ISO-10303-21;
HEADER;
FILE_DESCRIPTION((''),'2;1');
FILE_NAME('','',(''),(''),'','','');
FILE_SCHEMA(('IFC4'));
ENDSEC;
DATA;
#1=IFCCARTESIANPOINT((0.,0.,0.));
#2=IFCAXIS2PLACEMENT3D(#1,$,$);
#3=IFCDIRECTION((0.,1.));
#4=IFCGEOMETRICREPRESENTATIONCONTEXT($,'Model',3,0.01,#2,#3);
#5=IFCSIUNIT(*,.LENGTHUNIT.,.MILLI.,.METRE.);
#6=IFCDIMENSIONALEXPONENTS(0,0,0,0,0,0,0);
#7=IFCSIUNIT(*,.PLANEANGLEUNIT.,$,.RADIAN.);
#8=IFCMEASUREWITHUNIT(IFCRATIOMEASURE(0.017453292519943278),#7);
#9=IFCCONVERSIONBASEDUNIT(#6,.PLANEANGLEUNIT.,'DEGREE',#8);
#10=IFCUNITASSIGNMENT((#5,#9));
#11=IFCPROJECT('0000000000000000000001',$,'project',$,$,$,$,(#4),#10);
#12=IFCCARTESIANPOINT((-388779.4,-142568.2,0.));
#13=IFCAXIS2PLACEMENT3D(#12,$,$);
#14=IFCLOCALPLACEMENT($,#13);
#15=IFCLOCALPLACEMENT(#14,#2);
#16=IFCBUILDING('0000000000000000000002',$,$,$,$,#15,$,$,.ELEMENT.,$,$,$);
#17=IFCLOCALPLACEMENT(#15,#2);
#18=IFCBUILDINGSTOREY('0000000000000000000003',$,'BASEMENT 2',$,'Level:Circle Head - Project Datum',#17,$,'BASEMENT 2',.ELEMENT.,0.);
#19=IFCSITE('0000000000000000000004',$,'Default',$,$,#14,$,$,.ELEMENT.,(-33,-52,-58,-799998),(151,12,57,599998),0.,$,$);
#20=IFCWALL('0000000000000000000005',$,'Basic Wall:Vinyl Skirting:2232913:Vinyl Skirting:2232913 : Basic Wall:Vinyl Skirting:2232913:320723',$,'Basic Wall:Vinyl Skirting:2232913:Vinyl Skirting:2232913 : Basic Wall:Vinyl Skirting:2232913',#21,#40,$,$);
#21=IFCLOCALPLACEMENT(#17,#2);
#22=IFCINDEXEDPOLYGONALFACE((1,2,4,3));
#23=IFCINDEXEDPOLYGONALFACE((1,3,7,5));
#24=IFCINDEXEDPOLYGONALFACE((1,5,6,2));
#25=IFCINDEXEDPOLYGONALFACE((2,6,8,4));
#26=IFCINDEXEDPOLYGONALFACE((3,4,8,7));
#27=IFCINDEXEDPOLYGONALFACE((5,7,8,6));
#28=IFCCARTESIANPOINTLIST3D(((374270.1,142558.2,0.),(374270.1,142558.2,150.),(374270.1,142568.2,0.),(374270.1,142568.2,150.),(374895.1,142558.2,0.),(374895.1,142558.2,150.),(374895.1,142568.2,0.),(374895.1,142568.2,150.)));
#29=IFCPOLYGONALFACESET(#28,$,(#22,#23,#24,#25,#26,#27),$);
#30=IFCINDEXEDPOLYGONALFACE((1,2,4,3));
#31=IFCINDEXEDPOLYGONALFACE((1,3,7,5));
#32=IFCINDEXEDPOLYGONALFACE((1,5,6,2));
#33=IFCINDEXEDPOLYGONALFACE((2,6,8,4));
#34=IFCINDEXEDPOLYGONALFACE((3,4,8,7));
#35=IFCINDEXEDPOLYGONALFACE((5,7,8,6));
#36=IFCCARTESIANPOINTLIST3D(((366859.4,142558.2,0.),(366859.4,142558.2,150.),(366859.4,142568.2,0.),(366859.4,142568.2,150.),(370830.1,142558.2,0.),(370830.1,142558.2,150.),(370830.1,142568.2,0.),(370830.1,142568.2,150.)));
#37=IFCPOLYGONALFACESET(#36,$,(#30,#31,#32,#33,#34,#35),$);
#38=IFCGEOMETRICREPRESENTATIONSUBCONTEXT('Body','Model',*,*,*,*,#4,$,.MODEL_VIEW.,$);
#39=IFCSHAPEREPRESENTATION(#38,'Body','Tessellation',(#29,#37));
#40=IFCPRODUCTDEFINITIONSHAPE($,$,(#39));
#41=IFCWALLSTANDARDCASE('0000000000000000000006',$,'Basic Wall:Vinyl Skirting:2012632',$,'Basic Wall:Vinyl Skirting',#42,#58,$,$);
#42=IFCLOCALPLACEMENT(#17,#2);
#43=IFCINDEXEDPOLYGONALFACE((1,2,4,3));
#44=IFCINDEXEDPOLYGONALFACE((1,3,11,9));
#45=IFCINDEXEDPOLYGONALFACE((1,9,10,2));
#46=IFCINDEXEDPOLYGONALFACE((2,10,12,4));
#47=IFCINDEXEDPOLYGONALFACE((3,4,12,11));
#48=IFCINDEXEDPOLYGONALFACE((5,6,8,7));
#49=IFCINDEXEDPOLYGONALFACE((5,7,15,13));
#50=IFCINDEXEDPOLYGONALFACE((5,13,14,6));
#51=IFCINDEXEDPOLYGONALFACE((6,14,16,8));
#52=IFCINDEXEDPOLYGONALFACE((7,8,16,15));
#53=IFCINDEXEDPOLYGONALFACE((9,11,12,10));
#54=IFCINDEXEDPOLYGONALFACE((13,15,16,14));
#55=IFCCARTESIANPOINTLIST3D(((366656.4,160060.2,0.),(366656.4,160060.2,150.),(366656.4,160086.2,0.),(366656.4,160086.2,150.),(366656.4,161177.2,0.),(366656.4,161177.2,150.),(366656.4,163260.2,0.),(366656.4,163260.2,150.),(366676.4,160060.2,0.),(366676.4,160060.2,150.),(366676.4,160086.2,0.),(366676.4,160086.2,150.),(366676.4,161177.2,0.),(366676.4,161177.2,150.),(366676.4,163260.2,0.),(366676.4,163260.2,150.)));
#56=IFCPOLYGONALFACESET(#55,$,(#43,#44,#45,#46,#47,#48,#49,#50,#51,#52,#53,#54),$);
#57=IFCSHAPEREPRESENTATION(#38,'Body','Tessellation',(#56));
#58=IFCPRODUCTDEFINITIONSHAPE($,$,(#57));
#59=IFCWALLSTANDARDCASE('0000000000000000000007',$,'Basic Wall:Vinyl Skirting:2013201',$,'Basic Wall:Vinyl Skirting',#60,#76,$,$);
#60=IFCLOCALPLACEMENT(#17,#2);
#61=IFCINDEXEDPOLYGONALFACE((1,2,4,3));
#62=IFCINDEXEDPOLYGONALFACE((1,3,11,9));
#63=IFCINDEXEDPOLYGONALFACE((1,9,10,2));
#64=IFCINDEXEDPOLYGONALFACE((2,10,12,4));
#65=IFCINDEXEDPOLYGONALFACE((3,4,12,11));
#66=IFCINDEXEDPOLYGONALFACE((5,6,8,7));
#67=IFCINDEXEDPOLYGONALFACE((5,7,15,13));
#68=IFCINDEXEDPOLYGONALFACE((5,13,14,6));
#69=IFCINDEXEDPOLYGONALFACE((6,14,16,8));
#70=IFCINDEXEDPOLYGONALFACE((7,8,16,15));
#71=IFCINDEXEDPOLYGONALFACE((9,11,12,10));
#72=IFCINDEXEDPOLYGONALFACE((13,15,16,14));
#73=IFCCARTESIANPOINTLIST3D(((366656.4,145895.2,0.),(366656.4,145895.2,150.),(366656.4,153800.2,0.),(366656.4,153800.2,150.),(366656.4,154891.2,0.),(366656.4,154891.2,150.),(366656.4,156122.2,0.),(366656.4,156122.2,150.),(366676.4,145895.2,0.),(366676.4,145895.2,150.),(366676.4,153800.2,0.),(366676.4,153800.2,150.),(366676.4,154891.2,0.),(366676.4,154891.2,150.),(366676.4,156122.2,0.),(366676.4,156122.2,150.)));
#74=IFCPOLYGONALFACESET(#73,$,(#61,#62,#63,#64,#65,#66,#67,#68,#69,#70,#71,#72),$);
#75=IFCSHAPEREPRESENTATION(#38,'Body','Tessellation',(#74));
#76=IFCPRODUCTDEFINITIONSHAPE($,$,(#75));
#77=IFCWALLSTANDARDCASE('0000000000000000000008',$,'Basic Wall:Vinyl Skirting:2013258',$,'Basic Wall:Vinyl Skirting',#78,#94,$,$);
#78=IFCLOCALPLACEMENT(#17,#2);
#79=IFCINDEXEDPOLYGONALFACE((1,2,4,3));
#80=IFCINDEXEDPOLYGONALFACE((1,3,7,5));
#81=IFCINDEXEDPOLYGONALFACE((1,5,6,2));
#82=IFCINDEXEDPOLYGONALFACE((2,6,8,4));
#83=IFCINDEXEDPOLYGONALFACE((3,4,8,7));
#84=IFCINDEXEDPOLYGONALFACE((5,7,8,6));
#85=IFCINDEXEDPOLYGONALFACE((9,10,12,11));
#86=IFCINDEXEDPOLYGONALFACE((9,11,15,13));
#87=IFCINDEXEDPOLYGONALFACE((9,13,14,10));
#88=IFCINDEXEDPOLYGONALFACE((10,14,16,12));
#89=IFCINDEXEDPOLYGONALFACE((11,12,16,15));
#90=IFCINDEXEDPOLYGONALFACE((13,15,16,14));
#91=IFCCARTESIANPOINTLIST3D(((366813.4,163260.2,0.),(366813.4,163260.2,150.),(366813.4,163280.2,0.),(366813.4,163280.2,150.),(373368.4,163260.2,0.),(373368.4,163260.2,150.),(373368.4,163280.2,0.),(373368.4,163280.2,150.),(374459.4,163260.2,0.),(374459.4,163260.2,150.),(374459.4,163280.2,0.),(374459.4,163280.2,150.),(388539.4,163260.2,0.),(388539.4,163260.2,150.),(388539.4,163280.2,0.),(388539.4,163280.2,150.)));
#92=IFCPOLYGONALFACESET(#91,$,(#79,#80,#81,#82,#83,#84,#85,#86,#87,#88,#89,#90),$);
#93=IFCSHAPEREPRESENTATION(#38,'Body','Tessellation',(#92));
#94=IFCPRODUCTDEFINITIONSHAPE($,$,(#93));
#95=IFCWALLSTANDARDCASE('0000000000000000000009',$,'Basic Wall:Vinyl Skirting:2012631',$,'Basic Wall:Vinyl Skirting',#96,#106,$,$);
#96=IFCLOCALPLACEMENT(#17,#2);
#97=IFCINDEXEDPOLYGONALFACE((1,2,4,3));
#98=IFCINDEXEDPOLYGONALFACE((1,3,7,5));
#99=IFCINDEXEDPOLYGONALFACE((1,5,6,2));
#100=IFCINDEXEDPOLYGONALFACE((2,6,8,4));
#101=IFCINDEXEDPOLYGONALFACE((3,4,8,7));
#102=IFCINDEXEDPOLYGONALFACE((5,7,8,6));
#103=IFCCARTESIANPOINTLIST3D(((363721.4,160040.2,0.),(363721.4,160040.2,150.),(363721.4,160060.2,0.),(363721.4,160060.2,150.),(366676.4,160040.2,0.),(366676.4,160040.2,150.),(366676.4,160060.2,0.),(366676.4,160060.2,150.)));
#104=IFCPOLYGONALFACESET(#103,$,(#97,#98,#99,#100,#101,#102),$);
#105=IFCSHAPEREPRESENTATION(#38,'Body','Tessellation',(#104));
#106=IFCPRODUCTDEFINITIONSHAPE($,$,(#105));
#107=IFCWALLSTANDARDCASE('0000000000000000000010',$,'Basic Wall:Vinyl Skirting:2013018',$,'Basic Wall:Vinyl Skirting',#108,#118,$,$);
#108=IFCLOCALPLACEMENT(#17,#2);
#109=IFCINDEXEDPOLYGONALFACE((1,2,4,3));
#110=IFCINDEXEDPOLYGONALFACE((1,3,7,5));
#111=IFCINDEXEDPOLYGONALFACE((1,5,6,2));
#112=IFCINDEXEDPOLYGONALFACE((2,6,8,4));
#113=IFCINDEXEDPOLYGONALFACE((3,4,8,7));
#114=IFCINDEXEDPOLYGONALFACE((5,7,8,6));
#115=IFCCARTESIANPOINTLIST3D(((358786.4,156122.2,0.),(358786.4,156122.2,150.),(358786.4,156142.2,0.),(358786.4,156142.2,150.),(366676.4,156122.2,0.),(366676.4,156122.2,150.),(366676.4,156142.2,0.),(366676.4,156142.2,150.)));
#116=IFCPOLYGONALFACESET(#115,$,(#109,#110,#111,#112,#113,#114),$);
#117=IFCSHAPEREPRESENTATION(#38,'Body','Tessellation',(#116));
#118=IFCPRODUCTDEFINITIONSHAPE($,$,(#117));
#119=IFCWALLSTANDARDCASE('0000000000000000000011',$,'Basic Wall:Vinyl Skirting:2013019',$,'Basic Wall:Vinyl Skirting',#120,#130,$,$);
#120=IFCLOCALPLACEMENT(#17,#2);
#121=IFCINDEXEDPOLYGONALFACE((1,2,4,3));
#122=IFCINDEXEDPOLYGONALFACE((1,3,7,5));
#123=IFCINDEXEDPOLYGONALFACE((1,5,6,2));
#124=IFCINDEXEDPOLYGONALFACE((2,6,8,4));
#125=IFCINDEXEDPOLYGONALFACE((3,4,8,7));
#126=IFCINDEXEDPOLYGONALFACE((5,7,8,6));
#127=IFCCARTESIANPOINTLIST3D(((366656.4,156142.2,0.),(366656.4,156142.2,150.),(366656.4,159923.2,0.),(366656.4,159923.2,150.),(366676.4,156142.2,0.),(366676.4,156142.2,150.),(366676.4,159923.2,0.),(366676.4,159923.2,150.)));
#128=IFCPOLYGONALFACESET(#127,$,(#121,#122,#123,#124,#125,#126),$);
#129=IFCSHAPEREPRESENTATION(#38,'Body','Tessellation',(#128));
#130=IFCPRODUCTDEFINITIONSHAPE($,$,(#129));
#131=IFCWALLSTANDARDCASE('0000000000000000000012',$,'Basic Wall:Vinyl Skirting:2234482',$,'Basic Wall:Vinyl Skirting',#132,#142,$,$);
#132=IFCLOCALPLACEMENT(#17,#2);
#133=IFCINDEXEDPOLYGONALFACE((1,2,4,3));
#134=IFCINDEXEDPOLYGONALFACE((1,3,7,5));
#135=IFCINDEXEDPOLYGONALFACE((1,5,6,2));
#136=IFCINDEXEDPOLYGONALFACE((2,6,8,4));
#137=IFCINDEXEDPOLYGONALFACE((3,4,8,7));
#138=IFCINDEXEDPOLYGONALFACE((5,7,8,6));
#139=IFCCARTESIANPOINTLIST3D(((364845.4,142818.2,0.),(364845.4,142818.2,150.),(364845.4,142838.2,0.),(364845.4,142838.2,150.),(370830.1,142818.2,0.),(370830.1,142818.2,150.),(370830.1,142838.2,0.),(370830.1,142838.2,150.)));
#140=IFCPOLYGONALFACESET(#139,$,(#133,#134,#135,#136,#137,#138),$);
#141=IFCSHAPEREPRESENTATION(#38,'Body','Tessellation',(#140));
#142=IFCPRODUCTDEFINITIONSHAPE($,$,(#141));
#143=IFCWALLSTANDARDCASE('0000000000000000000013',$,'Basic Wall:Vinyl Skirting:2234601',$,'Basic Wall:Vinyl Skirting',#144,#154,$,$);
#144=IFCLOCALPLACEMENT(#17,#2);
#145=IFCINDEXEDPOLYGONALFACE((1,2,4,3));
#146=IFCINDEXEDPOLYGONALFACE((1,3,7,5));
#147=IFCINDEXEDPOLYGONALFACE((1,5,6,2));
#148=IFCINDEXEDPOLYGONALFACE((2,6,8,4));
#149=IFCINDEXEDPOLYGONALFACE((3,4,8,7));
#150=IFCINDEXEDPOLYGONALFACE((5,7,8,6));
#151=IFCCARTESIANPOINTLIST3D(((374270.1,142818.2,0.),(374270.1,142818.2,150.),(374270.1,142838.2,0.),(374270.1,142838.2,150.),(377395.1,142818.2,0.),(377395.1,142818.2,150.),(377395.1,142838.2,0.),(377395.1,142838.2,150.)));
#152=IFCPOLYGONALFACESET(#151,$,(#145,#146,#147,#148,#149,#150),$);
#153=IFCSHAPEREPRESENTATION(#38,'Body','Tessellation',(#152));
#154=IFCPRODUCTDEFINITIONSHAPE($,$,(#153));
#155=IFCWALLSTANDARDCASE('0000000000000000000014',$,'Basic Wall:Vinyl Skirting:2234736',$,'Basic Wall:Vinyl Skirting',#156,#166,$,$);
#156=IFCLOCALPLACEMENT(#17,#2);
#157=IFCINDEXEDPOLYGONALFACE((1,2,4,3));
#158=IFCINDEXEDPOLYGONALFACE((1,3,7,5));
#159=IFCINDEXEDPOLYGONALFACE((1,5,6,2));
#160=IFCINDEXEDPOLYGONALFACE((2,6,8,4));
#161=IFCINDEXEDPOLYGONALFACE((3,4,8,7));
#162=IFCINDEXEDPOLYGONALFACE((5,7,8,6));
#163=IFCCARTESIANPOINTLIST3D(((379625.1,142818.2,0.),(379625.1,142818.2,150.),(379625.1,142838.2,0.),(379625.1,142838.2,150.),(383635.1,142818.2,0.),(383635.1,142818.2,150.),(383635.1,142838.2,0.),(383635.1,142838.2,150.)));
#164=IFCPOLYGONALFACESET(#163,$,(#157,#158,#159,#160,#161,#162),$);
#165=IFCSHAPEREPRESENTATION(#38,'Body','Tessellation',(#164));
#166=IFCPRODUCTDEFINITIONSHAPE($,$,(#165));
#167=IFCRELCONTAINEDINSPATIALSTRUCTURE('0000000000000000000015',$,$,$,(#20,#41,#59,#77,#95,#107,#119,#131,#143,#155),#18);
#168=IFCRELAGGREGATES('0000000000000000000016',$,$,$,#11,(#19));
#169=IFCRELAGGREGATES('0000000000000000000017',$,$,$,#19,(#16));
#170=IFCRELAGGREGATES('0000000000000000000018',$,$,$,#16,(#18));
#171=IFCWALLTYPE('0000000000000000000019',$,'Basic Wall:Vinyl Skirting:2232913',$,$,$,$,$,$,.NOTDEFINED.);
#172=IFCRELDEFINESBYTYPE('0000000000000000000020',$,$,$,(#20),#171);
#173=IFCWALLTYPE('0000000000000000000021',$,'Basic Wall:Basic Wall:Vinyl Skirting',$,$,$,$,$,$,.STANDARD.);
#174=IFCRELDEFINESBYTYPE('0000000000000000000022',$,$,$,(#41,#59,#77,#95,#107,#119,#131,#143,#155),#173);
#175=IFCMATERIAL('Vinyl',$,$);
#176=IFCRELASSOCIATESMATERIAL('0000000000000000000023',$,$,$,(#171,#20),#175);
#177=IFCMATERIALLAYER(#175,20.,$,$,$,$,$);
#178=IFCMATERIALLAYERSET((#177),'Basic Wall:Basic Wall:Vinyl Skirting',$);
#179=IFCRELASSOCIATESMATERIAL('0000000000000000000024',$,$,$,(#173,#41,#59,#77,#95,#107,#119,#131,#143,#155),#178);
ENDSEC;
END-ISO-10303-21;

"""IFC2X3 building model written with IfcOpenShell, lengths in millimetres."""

from ifc_helpers import new_model, entity, si_unit, converted_unit, direction, frame, frame_2d, origin, origin_2d_with_axis, place, context, subcontext, project, spatial, rectangle, extrude, material, layer, layer_set, layer_usage, type_object, element, save


model = new_model("IFC2X3")

# Units and contexts
model_context = context("Model", 3, precision=0.01, world=origin(), true_north=direction((0.0, 1.0)))
body_context = subcontext(model_context, "Body", "Model", "MODEL_VIEW")
ifc_project = project(units=[si_unit("LENGTHUNIT", "METRE", prefix="MILLI"), converted_unit("PLANEANGLEUNIT", "DEGREE", entity("IfcRatioMeasure", 0.017453292519943278), si_unit("PLANEANGLEUNIT", "RADIAN"), dimensions=[0, 0, 0, 0, 0, 0, 0])], contexts=[model_context])

# Site, building, storey
site_placement = place(None, frame((-388779.4, -142568.2, 0.0)))
site = spatial("IfcSite", under=ifc_project, at=site_placement, Name="Default", CompositionType="ELEMENT", RefLatitude=(-33, -52, -58, -799998), RefLongitude=(151, 12, 57, 599998), RefElevation=0.0)
building_placement = place(site_placement, origin())
building = spatial("IfcBuilding", under=site, at=building_placement, CompositionType="ELEMENT")
storey_placement = place(building_placement, origin())
storey = spatial("IfcBuildingStorey", under=building, at=storey_placement, Name="BASEMENT 2", ObjectType="Level:Circle Head - Project Datum", LongName="BASEMENT 2", CompositionType="ELEMENT", Elevation=0.0)

# Wall
ifc_material_1 = material(Name="Vinyl")
wall_type_1 = type_object("IfcWallType", Name="Basic Wall:Vinyl Skirting:2232913", PredefinedType="NOTDEFINED", material=ifc_material_1)
wall_1_placement = place(storey_placement, frame((366859.4, 142558.2, 0.0)))
element("IfcWall", 1, at=wall_1_placement, inside=storey, type_object=wall_type_1, material=ifc_material_1, Name="Basic Wall:Vinyl Skirting:2232913:Vinyl Skirting:2232913 : Basic Wall:Vinyl Skirting:2232913:320723", ObjectType="Basic Wall:Vinyl Skirting:2232913:Vinyl Skirting:2232913 : Basic Wall:Vinyl Skirting:2232913", context=body_context, shape_type="SweptSolid", body=[
    extrude(rectangle(XDim=625.0, YDim=10.0, at=origin_2d_with_axis()), frame((7723.2, 5.0, 0.0), z_axis=(0.0, 0.0, 1.0), x_axis=(-1.0, 0.0, 0.0)), (0.0, 0.0, 1.0), 150.0),
    extrude(rectangle(XDim=3970.7, YDim=10.0, at=origin_2d_with_axis()), frame((1985.4, 5.0, 0.0), z_axis=(0.0, 0.0, 1.0), x_axis=(-1.0, 0.0, 0.0)), (0.0, 0.0, 1.0), 150.0),
])

# Shared definitions
ifc_layer_1 = layer(ifc_material_1, 20.0)
ifc_layer_set_1 = layer_set([ifc_layer_1], Name="Basic Wall:Basic Wall:Vinyl Skirting")
wall_type_2 = type_object("IfcWallType", Name="Basic Wall:Basic Wall:Vinyl Skirting", PredefinedType="STANDARD", material=ifc_layer_set_1)

# Wall, opening
ifc_layer_usage_1 = layer_usage(ifc_layer_set_1, "AXIS2", "NEGATIVE", 10.0)
wall_2_placement = place(storey_placement, frame((366666.4, 163260.2, 0.0), z_axis=(0.0, 0.0, 1.0), x_axis=(0.0, -1.0, 0.0)))
wall_2 = element("IfcWallStandardCase", 2, at=wall_2_placement, inside=storey, type_object=wall_type_2, material=ifc_layer_usage_1, Name="Basic Wall:Vinyl Skirting:2012632", ObjectType="Basic Wall:Vinyl Skirting", context=body_context, shape_type="SweptSolid", body=[
    extrude(rectangle(XDim=20.0, YDim=3200.0, at=frame_2d((1600.0, 0.0), x_axis=(0.0, -1.0))), origin(), (0.0, 0.0, 1.0), 150.0),
])
opening_1_placement = place(wall_2_placement, origin())
element("IfcOpeningElement", 3, at=opening_1_placement, cuts=wall_2, ObjectType="Opening", context=body_context, shape_type="SweptSolid", body=[
    extrude(rectangle(XDim=2185.0, YDim=1091.0, at=origin_2d_with_axis()), frame((2628.5, -10.0, 1092.5), z_axis=(0.0, 1.0, 0.0), x_axis=(0.0, 0.0, -1.0)), (0.0, 0.0, 1.0), 20.0),
])

# Walls, openings
ifc_layer_usage_2 = layer_usage(ifc_layer_set_1, "AXIS2", "NEGATIVE", 10.0)
wall_3_placement = place(storey_placement, frame((366666.4, 156122.2, 0.0), z_axis=(0.0, 0.0, 1.0), x_axis=(0.0, -1.0, 0.0)))
wall_3 = element("IfcWallStandardCase", 4, at=wall_3_placement, inside=storey, type_object=wall_type_2, material=ifc_layer_usage_2, Name="Basic Wall:Vinyl Skirting:2013201", ObjectType="Basic Wall:Vinyl Skirting", context=body_context, shape_type="SweptSolid", body=[
    extrude(rectangle(XDim=20.0, YDim=10227.0, at=frame_2d((5113.5, 0.0), x_axis=(0.0, -1.0))), origin(), (0.0, 0.0, 1.0), 150.0),
])
opening_2_placement = place(wall_3_placement, origin())
element("IfcOpeningElement", 5, at=opening_2_placement, cuts=wall_3, ObjectType="Opening", context=body_context, shape_type="SweptSolid", body=[
    extrude(rectangle(XDim=2185.0, YDim=1091.0, at=origin_2d_with_axis()), frame((1776.5, -10.0, 1092.5), z_axis=(0.0, 1.0, 0.0), x_axis=(0.0, 0.0, -1.0)), (0.0, 0.0, 1.0), 20.0),
])
ifc_layer_usage_3 = layer_usage(ifc_layer_set_1, "AXIS2", "NEGATIVE", 10.0)
wall_4_placement = place(storey_placement, frame((388539.4, 163270.2, 0.0), z_axis=(0.0, 0.0, 1.0), x_axis=(-1.0, 0.0, 0.0)))
wall_4 = element("IfcWallStandardCase", 6, at=wall_4_placement, inside=storey, type_object=wall_type_2, material=ifc_layer_usage_3, Name="Basic Wall:Vinyl Skirting:2013258", ObjectType="Basic Wall:Vinyl Skirting", context=body_context, shape_type="SweptSolid", body=[
    extrude(rectangle(XDim=20.0, YDim=21726.0, at=frame_2d((10863.0, 0.0), x_axis=(0.0, -1.0))), origin(), (0.0, 0.0, 1.0), 150.0),
])
opening_3_placement = place(wall_4_placement, origin())
element("IfcOpeningElement", 7, at=opening_3_placement, cuts=wall_4, ObjectType="Opening", context=body_context, shape_type="SweptSolid", body=[
    extrude(rectangle(XDim=2185.0, YDim=1091.0, at=origin_2d_with_axis()), frame((14625.5, -10.0, 1092.5), z_axis=(0.0, 1.0, 0.0), x_axis=(0.0, 0.0, -1.0)), (0.0, 0.0, 1.0), 20.0),
])

# Walls
ifc_layer_usage_4 = layer_usage(ifc_layer_set_1, "AXIS2", "NEGATIVE", 10.0)
wall_5_placement = place(storey_placement, frame((366676.4, 160050.2, 0.0), z_axis=(0.0, 0.0, 1.0), x_axis=(-1.0, 0.0, 0.0)))
element("IfcWallStandardCase", 8, at=wall_5_placement, inside=storey, type_object=wall_type_2, material=ifc_layer_usage_4, Name="Basic Wall:Vinyl Skirting:2012631", ObjectType="Basic Wall:Vinyl Skirting", context=body_context, shape_type="SweptSolid", body=[
    extrude(rectangle(XDim=2955.0, YDim=20.0, at=frame_2d((1477.5, 0.0), x_axis=(-1.0, 0.0))), origin(), (0.0, 0.0, 1.0), 150.0),
])
ifc_layer_usage_5 = layer_usage(ifc_layer_set_1, "AXIS2", "NEGATIVE", 10.0)
wall_6_placement = place(storey_placement, frame((366676.4, 156132.2, 0.0), z_axis=(0.0, 0.0, 1.0), x_axis=(-1.0, 0.0, 0.0)))
element("IfcWallStandardCase", 9, at=wall_6_placement, inside=storey, type_object=wall_type_2, material=ifc_layer_usage_5, Name="Basic Wall:Vinyl Skirting:2013018", ObjectType="Basic Wall:Vinyl Skirting", context=body_context, shape_type="SweptSolid", body=[
    extrude(rectangle(XDim=7890.0, YDim=20.0, at=frame_2d((3945.0, 0.0), x_axis=(-1.0, 0.0))), origin(), (0.0, 0.0, 1.0), 150.0),
])
ifc_layer_usage_6 = layer_usage(ifc_layer_set_1, "AXIS2", "NEGATIVE", 10.0)
wall_7_placement = place(storey_placement, frame((366666.4, 159923.2, 0.0), z_axis=(0.0, 0.0, 1.0), x_axis=(0.0, -1.0, 0.0)))
element("IfcWallStandardCase", 10, at=wall_7_placement, inside=storey, type_object=wall_type_2, material=ifc_layer_usage_6, Name="Basic Wall:Vinyl Skirting:2013019", ObjectType="Basic Wall:Vinyl Skirting", context=body_context, shape_type="SweptSolid", body=[
    extrude(rectangle(XDim=3781.0, YDim=20.0, at=frame_2d((1890.5, 0.0), x_axis=(-1.0, 0.0))), origin(), (0.0, 0.0, 1.0), 150.0),
])
ifc_layer_usage_7 = layer_usage(ifc_layer_set_1, "AXIS2", "NEGATIVE", 10.0)
wall_8_placement = place(storey_placement, frame((364845.4, 142828.2, 0.0)))
element("IfcWallStandardCase", 11, at=wall_8_placement, inside=storey, type_object=wall_type_2, material=ifc_layer_usage_7, Name="Basic Wall:Vinyl Skirting:2234482", ObjectType="Basic Wall:Vinyl Skirting", context=body_context, shape_type="SweptSolid", body=[
    extrude(rectangle(XDim=5984.7, YDim=20.0, at=frame_2d((2992.3, 0.0), x_axis=(-1.0, 0.0))), origin(), (0.0, 0.0, 1.0), 150.0),
])
ifc_layer_usage_8 = layer_usage(ifc_layer_set_1, "AXIS2", "NEGATIVE", 10.0)
wall_9_placement = place(storey_placement, frame((374270.1, 142828.2, 0.0)))
element("IfcWallStandardCase", 12, at=wall_9_placement, inside=storey, type_object=wall_type_2, material=ifc_layer_usage_8, Name="Basic Wall:Vinyl Skirting:2234601", ObjectType="Basic Wall:Vinyl Skirting", context=body_context, shape_type="SweptSolid", body=[
    extrude(rectangle(XDim=3125.0, YDim=20.0, at=frame_2d((1562.5, 0.0), x_axis=(-1.0, 0.0))), origin(), (0.0, 0.0, 1.0), 150.0),
])
ifc_layer_usage_9 = layer_usage(ifc_layer_set_1, "AXIS2", "NEGATIVE", 10.0)
wall_10_placement = place(storey_placement, frame((379625.1, 142828.2, 0.0)))
element("IfcWallStandardCase", 13, at=wall_10_placement, inside=storey, type_object=wall_type_2, material=ifc_layer_usage_9, Name="Basic Wall:Vinyl Skirting:2234736", ObjectType="Basic Wall:Vinyl Skirting", context=body_context, shape_type="SweptSolid", body=[
    extrude(rectangle(XDim=4010.0, YDim=20.0, at=frame_2d((2005.0, 0.0), x_axis=(-1.0, 0.0))), origin(), (0.0, 0.0, 1.0), 150.0),
])

save(model, "model.ifc")
